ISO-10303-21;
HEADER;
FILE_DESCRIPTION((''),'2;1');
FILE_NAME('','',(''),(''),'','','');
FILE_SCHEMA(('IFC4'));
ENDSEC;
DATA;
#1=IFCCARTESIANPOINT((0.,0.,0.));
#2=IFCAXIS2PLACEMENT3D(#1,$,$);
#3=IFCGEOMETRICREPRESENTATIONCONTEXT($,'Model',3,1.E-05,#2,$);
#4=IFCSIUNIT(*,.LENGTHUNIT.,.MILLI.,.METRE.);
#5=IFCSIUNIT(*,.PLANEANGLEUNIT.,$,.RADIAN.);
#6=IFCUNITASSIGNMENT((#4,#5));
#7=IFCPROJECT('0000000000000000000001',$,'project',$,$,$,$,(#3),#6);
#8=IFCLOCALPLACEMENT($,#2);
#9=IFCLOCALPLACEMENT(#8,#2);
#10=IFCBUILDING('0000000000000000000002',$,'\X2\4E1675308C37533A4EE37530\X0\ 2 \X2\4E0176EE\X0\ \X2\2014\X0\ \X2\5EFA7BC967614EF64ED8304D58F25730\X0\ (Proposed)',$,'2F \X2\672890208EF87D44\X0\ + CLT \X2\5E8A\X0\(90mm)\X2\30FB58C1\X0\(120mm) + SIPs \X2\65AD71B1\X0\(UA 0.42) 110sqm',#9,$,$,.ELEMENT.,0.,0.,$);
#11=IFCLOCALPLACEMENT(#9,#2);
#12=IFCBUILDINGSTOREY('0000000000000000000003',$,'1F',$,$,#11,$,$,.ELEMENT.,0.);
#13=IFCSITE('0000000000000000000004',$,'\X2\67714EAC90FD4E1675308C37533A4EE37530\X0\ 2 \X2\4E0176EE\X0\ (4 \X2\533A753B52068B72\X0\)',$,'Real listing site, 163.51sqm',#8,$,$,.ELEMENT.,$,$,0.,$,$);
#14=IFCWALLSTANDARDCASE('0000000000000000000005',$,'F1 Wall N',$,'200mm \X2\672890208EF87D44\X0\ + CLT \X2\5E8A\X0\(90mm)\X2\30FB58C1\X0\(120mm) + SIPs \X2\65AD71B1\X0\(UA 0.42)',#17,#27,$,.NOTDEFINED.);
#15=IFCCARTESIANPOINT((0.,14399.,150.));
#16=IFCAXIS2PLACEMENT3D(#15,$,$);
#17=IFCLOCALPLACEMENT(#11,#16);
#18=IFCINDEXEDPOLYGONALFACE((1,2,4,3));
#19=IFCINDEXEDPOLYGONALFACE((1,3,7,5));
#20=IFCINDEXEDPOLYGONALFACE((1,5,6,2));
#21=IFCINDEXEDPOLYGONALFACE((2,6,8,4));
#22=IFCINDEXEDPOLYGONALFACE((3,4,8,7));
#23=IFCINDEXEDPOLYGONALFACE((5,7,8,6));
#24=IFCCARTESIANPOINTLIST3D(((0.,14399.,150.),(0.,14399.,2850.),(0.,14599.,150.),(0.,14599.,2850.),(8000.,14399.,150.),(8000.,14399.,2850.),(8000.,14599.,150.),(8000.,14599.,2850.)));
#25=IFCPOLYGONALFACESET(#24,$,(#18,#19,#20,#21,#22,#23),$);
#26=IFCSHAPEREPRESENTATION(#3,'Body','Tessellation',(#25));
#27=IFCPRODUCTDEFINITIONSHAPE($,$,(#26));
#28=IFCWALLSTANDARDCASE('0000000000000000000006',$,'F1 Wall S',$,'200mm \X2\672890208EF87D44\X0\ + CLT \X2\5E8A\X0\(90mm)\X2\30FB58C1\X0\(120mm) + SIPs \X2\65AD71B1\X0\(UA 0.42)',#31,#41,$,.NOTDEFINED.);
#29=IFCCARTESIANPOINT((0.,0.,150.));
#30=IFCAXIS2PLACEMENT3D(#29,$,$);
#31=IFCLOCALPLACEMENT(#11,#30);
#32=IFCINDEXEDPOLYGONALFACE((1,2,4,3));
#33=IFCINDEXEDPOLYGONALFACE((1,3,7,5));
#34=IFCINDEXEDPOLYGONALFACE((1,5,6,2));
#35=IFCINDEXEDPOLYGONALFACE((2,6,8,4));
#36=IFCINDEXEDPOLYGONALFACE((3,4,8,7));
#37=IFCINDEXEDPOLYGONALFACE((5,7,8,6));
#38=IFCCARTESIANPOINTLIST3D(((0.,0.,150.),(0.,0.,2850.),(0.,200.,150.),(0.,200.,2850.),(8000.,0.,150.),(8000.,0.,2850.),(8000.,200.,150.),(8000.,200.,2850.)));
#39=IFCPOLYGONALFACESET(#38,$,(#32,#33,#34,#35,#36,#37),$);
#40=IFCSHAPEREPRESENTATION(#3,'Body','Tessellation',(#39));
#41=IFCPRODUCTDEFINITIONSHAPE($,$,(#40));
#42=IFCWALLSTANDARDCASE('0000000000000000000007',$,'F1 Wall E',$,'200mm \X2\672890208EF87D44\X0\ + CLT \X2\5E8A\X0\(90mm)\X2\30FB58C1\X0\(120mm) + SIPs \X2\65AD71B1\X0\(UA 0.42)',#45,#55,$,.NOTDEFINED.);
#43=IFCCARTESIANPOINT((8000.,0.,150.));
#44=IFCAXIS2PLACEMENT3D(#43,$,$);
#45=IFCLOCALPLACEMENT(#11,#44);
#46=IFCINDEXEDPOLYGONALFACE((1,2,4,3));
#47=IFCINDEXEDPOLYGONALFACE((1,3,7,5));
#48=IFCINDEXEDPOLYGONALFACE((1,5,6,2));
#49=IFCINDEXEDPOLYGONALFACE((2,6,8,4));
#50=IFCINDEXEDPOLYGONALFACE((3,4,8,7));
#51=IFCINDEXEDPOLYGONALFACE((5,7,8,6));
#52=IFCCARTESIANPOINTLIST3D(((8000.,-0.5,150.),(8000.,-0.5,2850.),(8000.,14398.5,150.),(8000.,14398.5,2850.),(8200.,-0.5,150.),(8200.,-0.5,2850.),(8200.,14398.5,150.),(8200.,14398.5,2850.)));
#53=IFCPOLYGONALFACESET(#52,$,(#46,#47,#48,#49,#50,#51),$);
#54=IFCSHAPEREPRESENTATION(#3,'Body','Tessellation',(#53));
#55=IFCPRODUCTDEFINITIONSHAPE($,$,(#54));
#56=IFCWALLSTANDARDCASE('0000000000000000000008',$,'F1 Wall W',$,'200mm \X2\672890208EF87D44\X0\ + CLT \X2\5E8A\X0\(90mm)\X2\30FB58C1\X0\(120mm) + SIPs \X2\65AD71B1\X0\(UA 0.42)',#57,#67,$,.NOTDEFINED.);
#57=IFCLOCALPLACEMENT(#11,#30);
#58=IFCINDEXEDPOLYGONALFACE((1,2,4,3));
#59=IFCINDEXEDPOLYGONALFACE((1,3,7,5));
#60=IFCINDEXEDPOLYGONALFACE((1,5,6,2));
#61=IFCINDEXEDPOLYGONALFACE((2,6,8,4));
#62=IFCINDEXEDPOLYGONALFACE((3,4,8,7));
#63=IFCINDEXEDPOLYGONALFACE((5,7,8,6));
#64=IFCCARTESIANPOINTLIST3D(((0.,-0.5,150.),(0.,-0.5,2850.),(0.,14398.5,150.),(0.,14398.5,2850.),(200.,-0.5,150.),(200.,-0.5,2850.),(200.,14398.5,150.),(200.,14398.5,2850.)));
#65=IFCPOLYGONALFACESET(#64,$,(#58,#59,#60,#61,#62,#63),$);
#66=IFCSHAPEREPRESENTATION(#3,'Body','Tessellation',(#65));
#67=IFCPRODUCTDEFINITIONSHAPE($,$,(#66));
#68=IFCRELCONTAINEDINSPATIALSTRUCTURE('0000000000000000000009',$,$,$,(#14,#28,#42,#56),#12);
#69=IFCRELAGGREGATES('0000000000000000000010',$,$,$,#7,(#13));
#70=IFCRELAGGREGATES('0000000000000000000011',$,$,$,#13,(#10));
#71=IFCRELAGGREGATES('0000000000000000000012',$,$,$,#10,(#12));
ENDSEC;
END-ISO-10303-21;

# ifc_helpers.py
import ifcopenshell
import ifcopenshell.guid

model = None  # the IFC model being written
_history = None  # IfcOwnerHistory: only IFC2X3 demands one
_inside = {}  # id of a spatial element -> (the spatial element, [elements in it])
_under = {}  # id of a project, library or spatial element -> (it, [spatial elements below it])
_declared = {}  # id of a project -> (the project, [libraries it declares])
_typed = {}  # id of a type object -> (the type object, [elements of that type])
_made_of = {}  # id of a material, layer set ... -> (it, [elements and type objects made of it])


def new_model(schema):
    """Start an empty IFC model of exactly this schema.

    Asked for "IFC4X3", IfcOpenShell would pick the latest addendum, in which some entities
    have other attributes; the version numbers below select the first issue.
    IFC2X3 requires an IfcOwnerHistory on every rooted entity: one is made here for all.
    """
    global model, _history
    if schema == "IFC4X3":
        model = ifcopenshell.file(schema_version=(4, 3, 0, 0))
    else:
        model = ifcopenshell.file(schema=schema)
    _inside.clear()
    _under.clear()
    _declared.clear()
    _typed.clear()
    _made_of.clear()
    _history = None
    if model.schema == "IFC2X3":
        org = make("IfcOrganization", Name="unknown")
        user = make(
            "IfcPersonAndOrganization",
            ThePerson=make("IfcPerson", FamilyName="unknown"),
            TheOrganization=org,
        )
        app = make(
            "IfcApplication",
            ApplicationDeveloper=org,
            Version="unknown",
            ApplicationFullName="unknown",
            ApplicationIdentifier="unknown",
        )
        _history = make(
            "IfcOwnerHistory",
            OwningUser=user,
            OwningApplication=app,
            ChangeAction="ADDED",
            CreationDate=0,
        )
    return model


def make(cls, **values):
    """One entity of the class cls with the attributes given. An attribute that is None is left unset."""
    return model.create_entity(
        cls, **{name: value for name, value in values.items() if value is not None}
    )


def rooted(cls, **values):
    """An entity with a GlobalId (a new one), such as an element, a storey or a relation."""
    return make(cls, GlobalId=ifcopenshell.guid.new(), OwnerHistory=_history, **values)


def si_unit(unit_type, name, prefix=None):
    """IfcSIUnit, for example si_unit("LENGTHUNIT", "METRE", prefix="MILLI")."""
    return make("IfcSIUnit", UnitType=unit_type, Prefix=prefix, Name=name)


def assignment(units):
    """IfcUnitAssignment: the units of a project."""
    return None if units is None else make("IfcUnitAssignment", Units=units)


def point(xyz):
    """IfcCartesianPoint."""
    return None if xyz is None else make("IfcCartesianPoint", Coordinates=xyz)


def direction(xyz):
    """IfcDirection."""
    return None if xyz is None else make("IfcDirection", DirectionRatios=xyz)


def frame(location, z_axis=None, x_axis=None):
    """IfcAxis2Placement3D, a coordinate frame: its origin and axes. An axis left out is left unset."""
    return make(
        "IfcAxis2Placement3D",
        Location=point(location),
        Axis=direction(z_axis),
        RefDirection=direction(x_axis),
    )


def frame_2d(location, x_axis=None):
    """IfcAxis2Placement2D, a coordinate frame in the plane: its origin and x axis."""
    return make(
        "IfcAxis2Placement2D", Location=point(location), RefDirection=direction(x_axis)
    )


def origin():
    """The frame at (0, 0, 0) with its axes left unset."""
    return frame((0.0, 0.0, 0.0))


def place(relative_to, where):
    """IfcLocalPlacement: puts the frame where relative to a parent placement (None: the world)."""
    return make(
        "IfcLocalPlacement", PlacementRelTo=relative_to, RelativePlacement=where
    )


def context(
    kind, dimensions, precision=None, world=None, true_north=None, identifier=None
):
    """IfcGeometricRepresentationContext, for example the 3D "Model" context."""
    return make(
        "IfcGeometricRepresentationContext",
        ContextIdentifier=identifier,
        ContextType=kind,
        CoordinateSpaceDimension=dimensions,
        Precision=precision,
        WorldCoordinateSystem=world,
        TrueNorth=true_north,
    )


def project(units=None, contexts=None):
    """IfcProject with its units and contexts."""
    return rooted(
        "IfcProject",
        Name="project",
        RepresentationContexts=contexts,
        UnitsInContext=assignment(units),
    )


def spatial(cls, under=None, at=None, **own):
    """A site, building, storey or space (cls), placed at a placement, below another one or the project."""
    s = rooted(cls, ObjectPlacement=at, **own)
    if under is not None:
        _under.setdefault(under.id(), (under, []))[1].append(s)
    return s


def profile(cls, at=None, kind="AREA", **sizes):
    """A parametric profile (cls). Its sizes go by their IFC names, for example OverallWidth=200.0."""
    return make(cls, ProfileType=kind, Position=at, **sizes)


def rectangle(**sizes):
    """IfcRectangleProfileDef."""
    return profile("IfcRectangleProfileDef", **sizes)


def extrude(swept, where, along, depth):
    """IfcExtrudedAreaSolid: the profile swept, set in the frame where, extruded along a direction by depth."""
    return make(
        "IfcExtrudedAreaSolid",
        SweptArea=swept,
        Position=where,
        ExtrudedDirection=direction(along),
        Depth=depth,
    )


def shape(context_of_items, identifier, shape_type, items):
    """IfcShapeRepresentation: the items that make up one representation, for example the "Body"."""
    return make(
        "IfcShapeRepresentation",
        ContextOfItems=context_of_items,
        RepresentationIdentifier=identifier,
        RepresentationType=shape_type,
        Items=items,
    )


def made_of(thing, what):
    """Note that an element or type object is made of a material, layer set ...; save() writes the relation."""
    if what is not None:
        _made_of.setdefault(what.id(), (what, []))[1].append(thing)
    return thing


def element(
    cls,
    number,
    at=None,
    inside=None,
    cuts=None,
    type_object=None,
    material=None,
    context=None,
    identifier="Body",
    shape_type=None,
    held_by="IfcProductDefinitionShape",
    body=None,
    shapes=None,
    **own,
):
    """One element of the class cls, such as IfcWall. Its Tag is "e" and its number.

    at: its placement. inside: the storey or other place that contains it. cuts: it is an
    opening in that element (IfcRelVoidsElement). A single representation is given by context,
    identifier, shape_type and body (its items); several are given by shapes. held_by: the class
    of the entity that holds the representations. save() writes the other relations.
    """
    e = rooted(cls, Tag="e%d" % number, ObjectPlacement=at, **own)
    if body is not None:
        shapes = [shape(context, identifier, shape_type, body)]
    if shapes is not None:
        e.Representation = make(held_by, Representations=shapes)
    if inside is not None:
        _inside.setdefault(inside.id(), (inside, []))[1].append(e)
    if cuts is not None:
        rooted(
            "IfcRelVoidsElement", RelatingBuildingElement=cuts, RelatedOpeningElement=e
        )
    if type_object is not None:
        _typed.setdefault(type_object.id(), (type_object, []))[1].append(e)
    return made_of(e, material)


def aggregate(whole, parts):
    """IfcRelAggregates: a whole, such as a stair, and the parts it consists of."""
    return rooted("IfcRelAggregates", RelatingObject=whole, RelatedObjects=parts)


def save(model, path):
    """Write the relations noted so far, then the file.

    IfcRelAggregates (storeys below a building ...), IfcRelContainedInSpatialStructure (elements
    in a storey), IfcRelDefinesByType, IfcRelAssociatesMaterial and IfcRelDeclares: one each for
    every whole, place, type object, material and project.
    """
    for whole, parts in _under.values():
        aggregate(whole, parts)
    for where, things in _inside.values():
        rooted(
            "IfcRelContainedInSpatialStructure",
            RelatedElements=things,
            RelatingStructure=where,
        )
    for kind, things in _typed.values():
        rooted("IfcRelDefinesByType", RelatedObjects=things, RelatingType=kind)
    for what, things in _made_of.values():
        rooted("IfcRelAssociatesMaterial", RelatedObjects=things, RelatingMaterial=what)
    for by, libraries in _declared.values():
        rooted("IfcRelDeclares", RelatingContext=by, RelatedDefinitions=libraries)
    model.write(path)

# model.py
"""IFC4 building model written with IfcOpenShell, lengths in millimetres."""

from ifc_helpers import new_model, si_unit, frame, frame_2d, origin, place, context, project, spatial, rectangle, extrude, element, save


model = new_model("IFC4")

# Units and contexts
model_context = context("Model", 3, precision=1e-05, world=origin())
ifc_project = project(units=[si_unit("LENGTHUNIT", "METRE", prefix="MILLI"), si_unit("PLANEANGLEUNIT", "RADIAN")], contexts=[model_context])

# Site, building, storey
site_placement = place(None, origin())
site = spatial("IfcSite", under=ifc_project, at=site_placement, Name="東京都世田谷区代田 2 丁目 (4 区画分譲)", ObjectType="Real listing site, 163.51sqm", CompositionType="ELEMENT", RefElevation=0.0)
building_placement = place(site_placement, origin())
building = spatial("IfcBuilding", under=site, at=building_placement, Name="世田谷区代田 2 丁目 — 建築条件付き売地 (Proposed)", ObjectType="2F 木造軸組 + CLT 床(90mm)・壁(120mm) + SIPs 断熱(UA 0.42) 110sqm", CompositionType="ELEMENT", ElevationOfRefHeight=0.0, ElevationOfTerrain=0.0)
storey_placement = place(building_placement, origin())
storey = spatial("IfcBuildingStorey", under=building, at=storey_placement, Name="1F", CompositionType="ELEMENT", Elevation=0.0)

# Walls
wall_1_placement = place(storey_placement, frame((0.0, 14399.0, 150.0)))
element("IfcWallStandardCase", 1, at=wall_1_placement, inside=storey, Name="F1 Wall N", ObjectType="200mm 木造軸組 + CLT 床(90mm)・壁(120mm) + SIPs 断熱(UA 0.42)", PredefinedType="NOTDEFINED", context=model_context, shape_type="SweptSolid", body=[
    extrude(rectangle(XDim=8000.0, YDim=200.0, at=frame_2d((4000.0, 100.0))), frame((0.0, 14399.0, 150.0)), (0.0, 0.0, 1.0), 2700.0),
])
wall_2_placement = place(storey_placement, frame((0.0, 0.0, 150.0)))
element("IfcWallStandardCase", 2, at=wall_2_placement, inside=storey, Name="F1 Wall S", ObjectType="200mm 木造軸組 + CLT 床(90mm)・壁(120mm) + SIPs 断熱(UA 0.42)", PredefinedType="NOTDEFINED", context=model_context, shape_type="SweptSolid", body=[
    extrude(rectangle(XDim=8000.0, YDim=200.0, at=frame_2d((4000.0, 100.0))), frame((0.0, 0.0, 150.0)), (0.0, 0.0, 1.0), 2700.0),
])
wall_3_placement = place(storey_placement, frame((8000.0, 0.0, 150.0)))
element("IfcWallStandardCase", 3, at=wall_3_placement, inside=storey, Name="F1 Wall E", ObjectType="200mm 木造軸組 + CLT 床(90mm)・壁(120mm) + SIPs 断熱(UA 0.42)", PredefinedType="NOTDEFINED", context=model_context, shape_type="SweptSolid", body=[
    extrude(rectangle(XDim=200.0, YDim=14399.0, at=frame_2d((100.0, 7199.0))), frame((8000.0, 0.0, 150.0)), (0.0, 0.0, 1.0), 2700.0),
])
wall_4_placement = place(storey_placement, frame((0.0, 0.0, 150.0)))
element("IfcWallStandardCase", 4, at=wall_4_placement, inside=storey, Name="F1 Wall W", ObjectType="200mm 木造軸組 + CLT 床(90mm)・壁(120mm) + SIPs 断熱(UA 0.42)", PredefinedType="NOTDEFINED", context=model_context, shape_type="SweptSolid", body=[
    extrude(rectangle(XDim=200.0, YDim=14399.0, at=frame_2d((100.0, 7199.0))), frame((0.0, 0.0, 150.0)), (0.0, 0.0, 1.0), 2700.0),
])

save(model, "model.ifc")
